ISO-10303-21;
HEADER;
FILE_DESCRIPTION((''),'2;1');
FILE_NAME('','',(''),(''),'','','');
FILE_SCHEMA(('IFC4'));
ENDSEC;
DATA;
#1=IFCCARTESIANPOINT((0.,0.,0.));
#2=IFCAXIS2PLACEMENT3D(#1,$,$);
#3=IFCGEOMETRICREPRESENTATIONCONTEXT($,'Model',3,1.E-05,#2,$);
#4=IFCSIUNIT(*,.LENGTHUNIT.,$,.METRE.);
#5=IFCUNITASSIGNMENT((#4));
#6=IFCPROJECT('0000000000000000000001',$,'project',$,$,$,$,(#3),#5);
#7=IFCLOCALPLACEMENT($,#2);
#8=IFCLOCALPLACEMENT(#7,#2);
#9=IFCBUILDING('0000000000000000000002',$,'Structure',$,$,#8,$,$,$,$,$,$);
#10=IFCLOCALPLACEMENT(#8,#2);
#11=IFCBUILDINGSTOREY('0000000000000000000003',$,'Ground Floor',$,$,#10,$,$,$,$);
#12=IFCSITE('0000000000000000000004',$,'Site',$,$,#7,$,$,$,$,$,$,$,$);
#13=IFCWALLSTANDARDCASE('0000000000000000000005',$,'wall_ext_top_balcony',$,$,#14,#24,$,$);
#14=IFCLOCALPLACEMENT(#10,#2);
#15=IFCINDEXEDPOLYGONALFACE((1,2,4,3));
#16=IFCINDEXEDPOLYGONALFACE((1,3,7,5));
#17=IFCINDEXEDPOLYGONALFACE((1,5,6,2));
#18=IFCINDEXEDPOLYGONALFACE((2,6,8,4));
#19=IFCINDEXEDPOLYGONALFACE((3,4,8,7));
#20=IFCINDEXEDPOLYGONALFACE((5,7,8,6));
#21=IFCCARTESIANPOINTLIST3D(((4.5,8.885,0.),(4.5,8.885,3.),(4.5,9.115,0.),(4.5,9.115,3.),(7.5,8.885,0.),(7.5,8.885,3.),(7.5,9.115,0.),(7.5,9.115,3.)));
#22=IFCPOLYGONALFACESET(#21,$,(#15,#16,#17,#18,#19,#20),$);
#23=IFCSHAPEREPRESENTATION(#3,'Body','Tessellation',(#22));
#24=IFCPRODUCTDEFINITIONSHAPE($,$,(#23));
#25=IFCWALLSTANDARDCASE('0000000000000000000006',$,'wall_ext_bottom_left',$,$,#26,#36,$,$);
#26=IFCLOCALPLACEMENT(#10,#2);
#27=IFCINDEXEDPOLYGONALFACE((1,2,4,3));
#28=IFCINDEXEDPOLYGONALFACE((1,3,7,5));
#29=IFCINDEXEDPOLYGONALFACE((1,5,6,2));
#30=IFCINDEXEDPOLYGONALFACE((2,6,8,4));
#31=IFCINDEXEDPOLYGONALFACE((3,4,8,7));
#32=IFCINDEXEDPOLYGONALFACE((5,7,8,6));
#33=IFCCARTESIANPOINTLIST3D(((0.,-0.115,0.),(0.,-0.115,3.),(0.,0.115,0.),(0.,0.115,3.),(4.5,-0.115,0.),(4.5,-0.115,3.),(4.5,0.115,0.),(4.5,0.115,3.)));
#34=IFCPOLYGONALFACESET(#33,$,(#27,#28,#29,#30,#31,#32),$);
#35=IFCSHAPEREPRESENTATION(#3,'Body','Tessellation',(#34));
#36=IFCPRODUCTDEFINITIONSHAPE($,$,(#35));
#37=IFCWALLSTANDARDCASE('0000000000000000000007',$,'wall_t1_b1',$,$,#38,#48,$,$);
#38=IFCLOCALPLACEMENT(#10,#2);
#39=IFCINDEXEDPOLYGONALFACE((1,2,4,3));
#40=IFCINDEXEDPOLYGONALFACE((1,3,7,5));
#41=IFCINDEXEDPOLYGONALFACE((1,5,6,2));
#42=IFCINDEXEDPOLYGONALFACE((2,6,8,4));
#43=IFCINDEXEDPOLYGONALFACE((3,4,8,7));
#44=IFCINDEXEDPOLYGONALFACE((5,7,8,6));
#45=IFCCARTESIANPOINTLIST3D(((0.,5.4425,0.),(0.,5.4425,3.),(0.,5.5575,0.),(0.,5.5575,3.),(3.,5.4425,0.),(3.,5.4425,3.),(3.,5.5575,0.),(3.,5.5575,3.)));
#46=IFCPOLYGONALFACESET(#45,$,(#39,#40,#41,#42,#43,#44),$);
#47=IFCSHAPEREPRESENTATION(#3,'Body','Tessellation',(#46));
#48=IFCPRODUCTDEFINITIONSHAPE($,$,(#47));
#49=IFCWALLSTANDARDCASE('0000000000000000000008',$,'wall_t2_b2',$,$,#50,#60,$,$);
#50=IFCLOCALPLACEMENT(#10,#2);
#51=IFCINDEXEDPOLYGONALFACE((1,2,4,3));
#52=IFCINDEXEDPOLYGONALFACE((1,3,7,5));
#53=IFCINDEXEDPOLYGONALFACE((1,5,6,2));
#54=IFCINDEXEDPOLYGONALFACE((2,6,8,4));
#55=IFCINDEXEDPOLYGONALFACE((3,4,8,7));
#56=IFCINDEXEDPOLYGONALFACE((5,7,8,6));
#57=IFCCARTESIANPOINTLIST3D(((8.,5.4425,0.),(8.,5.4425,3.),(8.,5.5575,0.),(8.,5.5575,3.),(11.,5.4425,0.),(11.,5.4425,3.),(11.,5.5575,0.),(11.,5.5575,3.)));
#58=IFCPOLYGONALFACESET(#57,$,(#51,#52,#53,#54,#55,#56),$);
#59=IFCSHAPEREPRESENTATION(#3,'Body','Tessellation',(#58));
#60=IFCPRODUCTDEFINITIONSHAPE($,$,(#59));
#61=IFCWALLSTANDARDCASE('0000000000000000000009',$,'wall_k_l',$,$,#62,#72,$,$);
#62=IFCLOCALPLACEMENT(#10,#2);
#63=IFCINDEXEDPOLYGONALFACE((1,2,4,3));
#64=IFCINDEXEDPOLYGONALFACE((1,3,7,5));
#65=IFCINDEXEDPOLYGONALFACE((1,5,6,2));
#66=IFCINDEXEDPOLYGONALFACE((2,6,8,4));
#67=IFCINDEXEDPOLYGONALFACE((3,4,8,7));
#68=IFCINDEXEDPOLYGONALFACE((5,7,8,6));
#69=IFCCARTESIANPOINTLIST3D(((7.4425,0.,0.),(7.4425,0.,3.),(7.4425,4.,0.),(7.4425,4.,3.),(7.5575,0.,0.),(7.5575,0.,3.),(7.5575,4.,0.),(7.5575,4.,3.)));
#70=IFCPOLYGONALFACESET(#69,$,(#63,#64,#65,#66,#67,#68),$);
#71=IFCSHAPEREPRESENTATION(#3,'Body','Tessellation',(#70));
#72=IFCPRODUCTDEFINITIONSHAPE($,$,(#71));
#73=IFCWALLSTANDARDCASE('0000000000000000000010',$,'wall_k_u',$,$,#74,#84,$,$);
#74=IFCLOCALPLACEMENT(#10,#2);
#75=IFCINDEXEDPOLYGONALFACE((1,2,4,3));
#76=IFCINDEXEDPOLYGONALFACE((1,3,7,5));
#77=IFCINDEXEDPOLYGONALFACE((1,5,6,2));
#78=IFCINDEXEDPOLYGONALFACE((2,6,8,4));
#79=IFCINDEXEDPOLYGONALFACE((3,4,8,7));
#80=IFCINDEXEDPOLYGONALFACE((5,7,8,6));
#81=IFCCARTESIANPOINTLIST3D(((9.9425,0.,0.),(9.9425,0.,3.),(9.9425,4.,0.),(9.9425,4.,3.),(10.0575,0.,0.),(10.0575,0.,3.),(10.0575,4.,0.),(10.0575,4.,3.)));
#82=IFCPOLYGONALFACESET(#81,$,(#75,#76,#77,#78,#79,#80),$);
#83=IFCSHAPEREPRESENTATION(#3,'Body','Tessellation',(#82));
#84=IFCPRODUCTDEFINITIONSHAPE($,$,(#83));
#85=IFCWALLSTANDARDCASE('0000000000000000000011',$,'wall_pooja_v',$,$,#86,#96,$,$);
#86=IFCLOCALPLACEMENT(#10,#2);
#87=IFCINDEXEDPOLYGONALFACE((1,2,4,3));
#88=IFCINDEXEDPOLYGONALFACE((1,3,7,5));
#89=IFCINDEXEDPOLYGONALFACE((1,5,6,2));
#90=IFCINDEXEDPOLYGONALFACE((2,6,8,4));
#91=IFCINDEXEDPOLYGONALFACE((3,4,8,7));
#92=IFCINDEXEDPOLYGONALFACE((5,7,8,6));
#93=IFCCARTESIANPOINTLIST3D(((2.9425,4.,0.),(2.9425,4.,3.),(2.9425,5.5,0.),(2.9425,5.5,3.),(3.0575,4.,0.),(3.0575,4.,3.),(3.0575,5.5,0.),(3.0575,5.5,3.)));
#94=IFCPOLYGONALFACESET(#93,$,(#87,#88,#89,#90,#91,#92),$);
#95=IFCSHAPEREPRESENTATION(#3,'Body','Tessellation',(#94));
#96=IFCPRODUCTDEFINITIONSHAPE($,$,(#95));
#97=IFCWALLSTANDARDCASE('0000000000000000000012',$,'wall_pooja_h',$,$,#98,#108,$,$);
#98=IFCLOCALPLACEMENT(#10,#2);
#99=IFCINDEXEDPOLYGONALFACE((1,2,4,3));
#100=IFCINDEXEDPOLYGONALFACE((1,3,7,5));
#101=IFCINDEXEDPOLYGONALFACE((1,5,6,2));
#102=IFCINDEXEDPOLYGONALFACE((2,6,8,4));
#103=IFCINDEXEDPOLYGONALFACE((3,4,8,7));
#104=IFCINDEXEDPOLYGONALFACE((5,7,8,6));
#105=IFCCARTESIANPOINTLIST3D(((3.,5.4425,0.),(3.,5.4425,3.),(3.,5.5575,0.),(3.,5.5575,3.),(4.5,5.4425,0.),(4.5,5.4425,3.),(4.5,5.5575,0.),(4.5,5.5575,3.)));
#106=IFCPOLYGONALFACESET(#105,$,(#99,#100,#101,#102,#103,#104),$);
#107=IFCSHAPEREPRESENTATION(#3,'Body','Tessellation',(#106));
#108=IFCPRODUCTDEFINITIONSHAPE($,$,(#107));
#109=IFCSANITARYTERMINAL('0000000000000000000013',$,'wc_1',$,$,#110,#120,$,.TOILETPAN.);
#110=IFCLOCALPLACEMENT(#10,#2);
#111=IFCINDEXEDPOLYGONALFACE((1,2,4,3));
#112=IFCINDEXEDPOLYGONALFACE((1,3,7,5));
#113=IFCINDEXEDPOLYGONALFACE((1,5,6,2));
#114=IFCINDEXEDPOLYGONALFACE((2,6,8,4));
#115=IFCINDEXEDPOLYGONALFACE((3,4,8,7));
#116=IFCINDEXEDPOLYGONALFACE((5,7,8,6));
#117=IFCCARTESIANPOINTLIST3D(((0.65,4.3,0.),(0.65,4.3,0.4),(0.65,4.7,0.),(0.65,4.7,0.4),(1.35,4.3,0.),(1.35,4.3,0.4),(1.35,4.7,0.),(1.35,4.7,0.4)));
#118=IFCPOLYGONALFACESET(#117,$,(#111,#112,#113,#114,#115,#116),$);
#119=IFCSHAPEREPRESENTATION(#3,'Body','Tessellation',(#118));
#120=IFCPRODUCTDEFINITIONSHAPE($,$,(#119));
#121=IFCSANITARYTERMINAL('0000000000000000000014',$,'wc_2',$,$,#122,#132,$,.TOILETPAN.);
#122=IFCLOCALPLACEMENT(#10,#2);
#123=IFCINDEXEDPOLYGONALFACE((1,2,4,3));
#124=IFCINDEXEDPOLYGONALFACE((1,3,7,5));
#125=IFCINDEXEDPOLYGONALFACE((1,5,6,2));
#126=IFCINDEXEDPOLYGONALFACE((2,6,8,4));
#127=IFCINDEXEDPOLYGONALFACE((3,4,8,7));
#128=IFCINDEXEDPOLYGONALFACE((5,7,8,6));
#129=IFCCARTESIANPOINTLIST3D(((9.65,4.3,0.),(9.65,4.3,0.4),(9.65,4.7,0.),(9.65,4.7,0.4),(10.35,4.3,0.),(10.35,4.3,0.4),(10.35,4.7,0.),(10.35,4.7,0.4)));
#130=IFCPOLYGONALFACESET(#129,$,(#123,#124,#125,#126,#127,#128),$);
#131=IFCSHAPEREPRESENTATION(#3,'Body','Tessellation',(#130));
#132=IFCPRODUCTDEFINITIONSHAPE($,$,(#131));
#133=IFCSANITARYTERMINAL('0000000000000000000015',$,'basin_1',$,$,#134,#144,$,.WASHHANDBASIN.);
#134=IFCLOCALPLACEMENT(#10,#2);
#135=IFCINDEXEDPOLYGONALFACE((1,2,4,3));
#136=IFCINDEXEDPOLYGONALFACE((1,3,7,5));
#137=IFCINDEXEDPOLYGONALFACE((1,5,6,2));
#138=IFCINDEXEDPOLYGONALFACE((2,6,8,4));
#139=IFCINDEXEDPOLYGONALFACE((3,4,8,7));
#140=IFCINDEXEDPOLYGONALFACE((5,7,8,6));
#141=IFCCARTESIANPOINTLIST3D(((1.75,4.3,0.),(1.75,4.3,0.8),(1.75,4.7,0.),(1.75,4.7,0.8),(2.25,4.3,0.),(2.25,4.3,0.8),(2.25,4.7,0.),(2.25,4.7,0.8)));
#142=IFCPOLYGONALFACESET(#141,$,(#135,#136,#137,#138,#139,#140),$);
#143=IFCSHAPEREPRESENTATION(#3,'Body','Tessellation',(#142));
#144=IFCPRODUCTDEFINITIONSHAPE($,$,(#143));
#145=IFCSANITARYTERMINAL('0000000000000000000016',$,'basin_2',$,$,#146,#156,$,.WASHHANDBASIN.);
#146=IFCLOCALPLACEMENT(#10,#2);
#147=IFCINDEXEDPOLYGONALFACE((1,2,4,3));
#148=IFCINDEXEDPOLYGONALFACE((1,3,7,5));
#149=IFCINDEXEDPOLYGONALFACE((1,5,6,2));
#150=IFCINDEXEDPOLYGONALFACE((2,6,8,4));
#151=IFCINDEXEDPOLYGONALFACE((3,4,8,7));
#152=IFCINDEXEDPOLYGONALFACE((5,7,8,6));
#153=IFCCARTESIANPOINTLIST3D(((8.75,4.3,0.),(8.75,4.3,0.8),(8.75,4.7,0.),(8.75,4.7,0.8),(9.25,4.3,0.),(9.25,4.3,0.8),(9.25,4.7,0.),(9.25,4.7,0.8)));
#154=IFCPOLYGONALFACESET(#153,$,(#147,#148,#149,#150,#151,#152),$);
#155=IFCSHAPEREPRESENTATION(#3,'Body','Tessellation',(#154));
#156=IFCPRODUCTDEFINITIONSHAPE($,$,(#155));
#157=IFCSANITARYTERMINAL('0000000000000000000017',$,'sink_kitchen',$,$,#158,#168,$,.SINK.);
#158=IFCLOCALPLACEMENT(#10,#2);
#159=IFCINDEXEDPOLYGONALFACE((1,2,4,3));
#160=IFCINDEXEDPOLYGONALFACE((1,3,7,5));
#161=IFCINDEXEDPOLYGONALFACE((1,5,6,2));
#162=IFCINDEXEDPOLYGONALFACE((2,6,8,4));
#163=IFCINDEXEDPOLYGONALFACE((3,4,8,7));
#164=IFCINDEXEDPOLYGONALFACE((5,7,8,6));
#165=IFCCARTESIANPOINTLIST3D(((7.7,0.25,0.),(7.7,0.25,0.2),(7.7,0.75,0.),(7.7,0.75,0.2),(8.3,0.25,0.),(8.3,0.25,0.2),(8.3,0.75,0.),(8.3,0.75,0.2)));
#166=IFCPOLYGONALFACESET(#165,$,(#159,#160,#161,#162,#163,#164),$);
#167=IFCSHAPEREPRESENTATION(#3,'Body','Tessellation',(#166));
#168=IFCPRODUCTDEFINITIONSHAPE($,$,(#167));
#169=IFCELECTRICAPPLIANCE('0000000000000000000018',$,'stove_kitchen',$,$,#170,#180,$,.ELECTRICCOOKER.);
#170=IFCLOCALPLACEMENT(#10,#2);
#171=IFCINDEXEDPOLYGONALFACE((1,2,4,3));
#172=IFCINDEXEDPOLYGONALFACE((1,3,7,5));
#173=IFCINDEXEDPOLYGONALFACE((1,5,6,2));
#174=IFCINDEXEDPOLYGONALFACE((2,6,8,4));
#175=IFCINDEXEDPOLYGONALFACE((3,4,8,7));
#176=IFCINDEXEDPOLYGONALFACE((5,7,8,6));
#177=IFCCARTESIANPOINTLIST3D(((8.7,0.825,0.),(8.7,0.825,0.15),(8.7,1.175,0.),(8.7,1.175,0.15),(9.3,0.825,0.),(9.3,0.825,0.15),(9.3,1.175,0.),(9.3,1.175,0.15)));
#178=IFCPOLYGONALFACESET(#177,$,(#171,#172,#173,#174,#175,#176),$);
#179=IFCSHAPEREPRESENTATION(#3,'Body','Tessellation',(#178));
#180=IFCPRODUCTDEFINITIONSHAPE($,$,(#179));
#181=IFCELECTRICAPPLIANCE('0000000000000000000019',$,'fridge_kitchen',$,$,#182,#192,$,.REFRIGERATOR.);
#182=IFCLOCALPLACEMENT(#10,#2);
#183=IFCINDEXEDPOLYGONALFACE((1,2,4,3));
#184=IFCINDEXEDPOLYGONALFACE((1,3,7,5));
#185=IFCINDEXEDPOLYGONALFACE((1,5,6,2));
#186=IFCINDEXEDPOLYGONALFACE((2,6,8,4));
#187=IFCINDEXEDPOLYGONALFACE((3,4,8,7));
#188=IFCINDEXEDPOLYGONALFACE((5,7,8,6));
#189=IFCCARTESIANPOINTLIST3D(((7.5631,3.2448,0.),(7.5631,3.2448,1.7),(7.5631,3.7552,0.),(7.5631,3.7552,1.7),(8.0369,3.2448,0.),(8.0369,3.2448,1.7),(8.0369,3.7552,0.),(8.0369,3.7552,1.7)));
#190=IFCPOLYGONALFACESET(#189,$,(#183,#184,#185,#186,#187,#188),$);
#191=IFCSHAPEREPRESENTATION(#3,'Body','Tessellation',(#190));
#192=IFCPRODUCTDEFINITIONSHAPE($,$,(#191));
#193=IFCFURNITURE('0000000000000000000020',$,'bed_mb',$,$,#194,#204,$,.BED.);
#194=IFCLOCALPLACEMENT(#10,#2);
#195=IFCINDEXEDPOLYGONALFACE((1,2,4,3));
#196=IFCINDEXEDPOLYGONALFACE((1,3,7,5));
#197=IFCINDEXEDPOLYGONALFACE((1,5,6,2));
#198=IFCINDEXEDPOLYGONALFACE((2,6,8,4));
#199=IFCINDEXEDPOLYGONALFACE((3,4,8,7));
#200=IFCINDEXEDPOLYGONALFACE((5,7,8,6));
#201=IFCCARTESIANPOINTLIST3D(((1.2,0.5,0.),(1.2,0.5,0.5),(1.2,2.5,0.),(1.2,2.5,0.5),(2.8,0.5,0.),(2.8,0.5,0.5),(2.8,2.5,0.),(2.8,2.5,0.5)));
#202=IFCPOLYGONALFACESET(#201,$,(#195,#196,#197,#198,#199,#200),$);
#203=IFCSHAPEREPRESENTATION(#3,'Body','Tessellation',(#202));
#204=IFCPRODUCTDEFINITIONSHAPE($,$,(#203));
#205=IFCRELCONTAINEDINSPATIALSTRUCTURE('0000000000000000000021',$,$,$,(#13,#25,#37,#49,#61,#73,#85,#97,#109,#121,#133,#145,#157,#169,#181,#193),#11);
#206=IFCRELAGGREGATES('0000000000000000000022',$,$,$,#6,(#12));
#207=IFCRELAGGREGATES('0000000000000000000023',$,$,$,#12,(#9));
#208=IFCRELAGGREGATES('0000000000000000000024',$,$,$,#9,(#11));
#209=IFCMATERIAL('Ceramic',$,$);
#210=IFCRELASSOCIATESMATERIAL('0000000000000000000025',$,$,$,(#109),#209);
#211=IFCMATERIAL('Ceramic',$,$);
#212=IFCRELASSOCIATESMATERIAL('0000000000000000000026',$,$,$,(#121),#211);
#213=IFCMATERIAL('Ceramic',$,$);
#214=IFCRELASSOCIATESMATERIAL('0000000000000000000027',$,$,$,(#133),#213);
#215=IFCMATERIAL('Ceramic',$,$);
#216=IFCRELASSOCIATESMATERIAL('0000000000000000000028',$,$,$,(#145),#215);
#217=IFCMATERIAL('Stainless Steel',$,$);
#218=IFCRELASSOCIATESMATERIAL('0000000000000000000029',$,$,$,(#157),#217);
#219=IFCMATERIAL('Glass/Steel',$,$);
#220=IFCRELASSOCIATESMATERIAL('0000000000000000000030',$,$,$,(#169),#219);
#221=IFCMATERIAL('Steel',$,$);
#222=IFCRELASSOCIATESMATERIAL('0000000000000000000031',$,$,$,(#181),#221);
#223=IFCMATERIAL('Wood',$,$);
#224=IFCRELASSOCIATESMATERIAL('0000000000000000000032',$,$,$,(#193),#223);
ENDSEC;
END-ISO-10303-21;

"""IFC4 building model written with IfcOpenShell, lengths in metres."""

from ifc_helpers import new_model, si_unit, frame, origin, place, context, project, spatial, polyline, outline, extrude, material, element, save


model = new_model("IFC4")

# Units and contexts
model_context = context("Model", 3, precision=1e-05, world=origin())
ifc_project = project(units=[si_unit("LENGTHUNIT", "METRE")], contexts=[model_context])

# Site, building, storey
site_placement = place(None, origin())
site = spatial("IfcSite", under=ifc_project, at=site_placement, Name="Site")
building_placement = place(site_placement, origin())
building = spatial("IfcBuilding", under=site, at=building_placement, Name="Structure")
storey_placement = place(building_placement, origin())
storey = spatial("IfcBuildingStorey", under=building, at=storey_placement, Name="Ground Floor")

# Walls
wall_1_placement = place(storey_placement, frame((4.5, 9.0, 0.0), x_axis=(1.0, 0.0, 0.0)))
element("IfcWallStandardCase", 1, at=wall_1_placement, inside=storey, Name="wall_ext_top_balcony", context=model_context, shape_type="SweptSolid", body=[
    extrude(outline(polyline([(0.0, -0.115), (3.0, -0.115), (3.0, 0.115), (0.0, 0.115), (0.0, -0.115)])), origin(), (0.0, 0.0, 1.0), 3.0),
])
wall_2_placement = place(storey_placement, frame((0.0, 0.0, 0.0), x_axis=(1.0, 0.0, 0.0)))
element("IfcWallStandardCase", 2, at=wall_2_placement, inside=storey, Name="wall_ext_bottom_left", context=model_context, shape_type="SweptSolid", body=[
    extrude(outline(polyline([(0.0, -0.115), (4.5, -0.115), (4.5, 0.115), (0.0, 0.115), (0.0, -0.115)])), origin(), (0.0, 0.0, 1.0), 3.0),
])
for number, where, x_axis, name in (
    (3, (0.0, 5.5, 0.0), (1.0, 0.0, 0.0), "wall_t1_b1"),
    (4, (8.0, 5.5, 0.0), (1.0, 0.0, 0.0), "wall_t2_b2"),
):
    element("IfcWallStandardCase", number, at=place(storey_placement, frame(where, x_axis=x_axis)), inside=storey, Name=name, context=model_context, shape_type="SweptSolid", body=[
        extrude(outline(polyline([(0.0, -0.0575), (3.0, -0.0575), (3.0, 0.0575), (0.0, 0.0575), (0.0, -0.0575)])), origin(), (0.0, 0.0, 1.0), 3.0),
    ])
for number, where, x_axis, name in (
    (5, (7.5, 0.0, 0.0), (0.0, 1.0, 0.0), "wall_k_l"),
    (6, (10.0, 0.0, 0.0), (0.0, 1.0, 0.0), "wall_k_u"),
):
    element("IfcWallStandardCase", number, at=place(storey_placement, frame(where, x_axis=x_axis)), inside=storey, Name=name, context=model_context, shape_type="SweptSolid", body=[
        extrude(outline(polyline([(0.0, -0.0575), (4.0, -0.0575), (4.0, 0.0575), (0.0, 0.0575), (0.0, -0.0575)])), origin(), (0.0, 0.0, 1.0), 3.0),
    ])
for number, where, x_axis, name in (
    (7, (3.0, 4.0, 0.0), (0.0, 1.0, 0.0), "wall_pooja_v"),
    (8, (3.0, 5.5, 0.0), (1.0, 0.0, 0.0), "wall_pooja_h"),
):
    element("IfcWallStandardCase", number, at=place(storey_placement, frame(where, x_axis=x_axis)), inside=storey, Name=name, context=model_context, shape_type="SweptSolid", body=[
        extrude(outline(polyline([(0.0, -0.0575), (1.5, -0.0575), (1.5, 0.0575), (0.0, 0.0575), (0.0, -0.0575)])), origin(), (0.0, 0.0, 1.0), 3.0),
    ])

# Sanitary terminals
ifc_material_1 = material(Name="Ceramic")
sanitary_terminal_1_placement = place(storey_placement, frame((1.0, 4.5, 0.0)))
element("IfcSanitaryTerminal", 9, at=sanitary_terminal_1_placement, inside=storey, material=ifc_material_1, Name="wc_1", PredefinedType="TOILETPAN", context=model_context, shape_type="SweptSolid", body=[
    extrude(outline(polyline([(-0.35, -0.2), (0.35, -0.2), (0.35, 0.2), (-0.35, 0.2), (-0.35, -0.2)])), origin(), (0.0, 0.0, 1.0), 0.4),
])
ifc_material_2 = material(Name="Ceramic")
sanitary_terminal_2_placement = place(storey_placement, frame((10.0, 4.5, 0.0)))
element("IfcSanitaryTerminal", 10, at=sanitary_terminal_2_placement, inside=storey, material=ifc_material_2, Name="wc_2", PredefinedType="TOILETPAN", context=model_context, shape_type="SweptSolid", body=[
    extrude(outline(polyline([(-0.35, -0.2), (0.35, -0.2), (0.35, 0.2), (-0.35, 0.2), (-0.35, -0.2)])), origin(), (0.0, 0.0, 1.0), 0.4),
])
ifc_material_3 = material(Name="Ceramic")
sanitary_terminal_3_placement = place(storey_placement, frame((2.0, 4.5, 0.0)))
element("IfcSanitaryTerminal", 11, at=sanitary_terminal_3_placement, inside=storey, material=ifc_material_3, Name="basin_1", PredefinedType="WASHHANDBASIN", context=model_context, shape_type="SweptSolid", body=[
    extrude(outline(polyline([(-0.25, -0.2), (0.25, -0.2), (0.25, 0.2), (-0.25, 0.2), (-0.25, -0.2)])), origin(), (0.0, 0.0, 1.0), 0.8),
])
ifc_material_4 = material(Name="Ceramic")
sanitary_terminal_4_placement = place(storey_placement, frame((9.0, 4.5, 0.0)))
element("IfcSanitaryTerminal", 12, at=sanitary_terminal_4_placement, inside=storey, material=ifc_material_4, Name="basin_2", PredefinedType="WASHHANDBASIN", context=model_context, shape_type="SweptSolid", body=[
    extrude(outline(polyline([(-0.25, -0.2), (0.25, -0.2), (0.25, 0.2), (-0.25, 0.2), (-0.25, -0.2)])), origin(), (0.0, 0.0, 1.0), 0.8),
])
ifc_material_5 = material(Name="Stainless Steel")
sanitary_terminal_5_placement = place(storey_placement, frame((8.0, 0.5, 0.0)))
element("IfcSanitaryTerminal", 13, at=sanitary_terminal_5_placement, inside=storey, material=ifc_material_5, Name="sink_kitchen", PredefinedType="SINK", context=model_context, shape_type="SweptSolid", body=[
    extrude(outline(polyline([(-0.3, -0.25), (0.3, -0.25), (0.3, 0.25), (-0.3, 0.25), (-0.3, -0.25)])), origin(), (0.0, 0.0, 1.0), 0.2),
])

# Electric appliances
ifc_material_6 = material(Name="Glass/Steel")
electric_appliance_1_placement = place(storey_placement, frame((9.0, 1.0, 0.0)))
element("IfcElectricAppliance", 14, at=electric_appliance_1_placement, inside=storey, material=ifc_material_6, Name="stove_kitchen", PredefinedType="ELECTRICCOOKER", context=model_context, shape_type="SweptSolid", body=[
    extrude(outline(polyline([(-0.3, -0.175), (0.3, -0.175), (0.3, 0.175), (-0.3, 0.175), (-0.3, -0.175)])), origin(), (0.0, 0.0, 1.0), 0.15),
])
ifc_material_7 = material(Name="Steel")
electric_appliance_2_placement = place(storey_placement, frame((7.8, 3.5, 0.0)))
element("IfcElectricAppliance", 15, at=electric_appliance_2_placement, inside=storey, material=ifc_material_7, Name="fridge_kitchen", PredefinedType="REFRIGERATOR", context=model_context, shape_type="SweptSolid", body=[
    extrude(outline(polyline([(-0.2369, -0.2552), (0.2369, -0.2552), (0.2369, 0.2552), (-0.2369, 0.2552), (-0.2369, -0.2552)])), origin(), (0.0, 0.0, 1.0), 1.7),
])

# Furniture
ifc_material_8 = material(Name="Wood")
furniture_1_placement = place(storey_placement, frame((2.0, 1.5, 0.0)))
element("IfcFurniture", 16, at=furniture_1_placement, inside=storey, material=ifc_material_8, Name="bed_mb", PredefinedType="BED", context=model_context, shape_type="SweptSolid", body=[
    extrude(outline(polyline([(-0.8, -1.0), (0.8, -1.0), (0.8, 1.0), (-0.8, 1.0), (-0.8, -1.0)])), origin(), (0.0, 0.0, 1.0), 0.5),
])

save(model, "model.ifc")
